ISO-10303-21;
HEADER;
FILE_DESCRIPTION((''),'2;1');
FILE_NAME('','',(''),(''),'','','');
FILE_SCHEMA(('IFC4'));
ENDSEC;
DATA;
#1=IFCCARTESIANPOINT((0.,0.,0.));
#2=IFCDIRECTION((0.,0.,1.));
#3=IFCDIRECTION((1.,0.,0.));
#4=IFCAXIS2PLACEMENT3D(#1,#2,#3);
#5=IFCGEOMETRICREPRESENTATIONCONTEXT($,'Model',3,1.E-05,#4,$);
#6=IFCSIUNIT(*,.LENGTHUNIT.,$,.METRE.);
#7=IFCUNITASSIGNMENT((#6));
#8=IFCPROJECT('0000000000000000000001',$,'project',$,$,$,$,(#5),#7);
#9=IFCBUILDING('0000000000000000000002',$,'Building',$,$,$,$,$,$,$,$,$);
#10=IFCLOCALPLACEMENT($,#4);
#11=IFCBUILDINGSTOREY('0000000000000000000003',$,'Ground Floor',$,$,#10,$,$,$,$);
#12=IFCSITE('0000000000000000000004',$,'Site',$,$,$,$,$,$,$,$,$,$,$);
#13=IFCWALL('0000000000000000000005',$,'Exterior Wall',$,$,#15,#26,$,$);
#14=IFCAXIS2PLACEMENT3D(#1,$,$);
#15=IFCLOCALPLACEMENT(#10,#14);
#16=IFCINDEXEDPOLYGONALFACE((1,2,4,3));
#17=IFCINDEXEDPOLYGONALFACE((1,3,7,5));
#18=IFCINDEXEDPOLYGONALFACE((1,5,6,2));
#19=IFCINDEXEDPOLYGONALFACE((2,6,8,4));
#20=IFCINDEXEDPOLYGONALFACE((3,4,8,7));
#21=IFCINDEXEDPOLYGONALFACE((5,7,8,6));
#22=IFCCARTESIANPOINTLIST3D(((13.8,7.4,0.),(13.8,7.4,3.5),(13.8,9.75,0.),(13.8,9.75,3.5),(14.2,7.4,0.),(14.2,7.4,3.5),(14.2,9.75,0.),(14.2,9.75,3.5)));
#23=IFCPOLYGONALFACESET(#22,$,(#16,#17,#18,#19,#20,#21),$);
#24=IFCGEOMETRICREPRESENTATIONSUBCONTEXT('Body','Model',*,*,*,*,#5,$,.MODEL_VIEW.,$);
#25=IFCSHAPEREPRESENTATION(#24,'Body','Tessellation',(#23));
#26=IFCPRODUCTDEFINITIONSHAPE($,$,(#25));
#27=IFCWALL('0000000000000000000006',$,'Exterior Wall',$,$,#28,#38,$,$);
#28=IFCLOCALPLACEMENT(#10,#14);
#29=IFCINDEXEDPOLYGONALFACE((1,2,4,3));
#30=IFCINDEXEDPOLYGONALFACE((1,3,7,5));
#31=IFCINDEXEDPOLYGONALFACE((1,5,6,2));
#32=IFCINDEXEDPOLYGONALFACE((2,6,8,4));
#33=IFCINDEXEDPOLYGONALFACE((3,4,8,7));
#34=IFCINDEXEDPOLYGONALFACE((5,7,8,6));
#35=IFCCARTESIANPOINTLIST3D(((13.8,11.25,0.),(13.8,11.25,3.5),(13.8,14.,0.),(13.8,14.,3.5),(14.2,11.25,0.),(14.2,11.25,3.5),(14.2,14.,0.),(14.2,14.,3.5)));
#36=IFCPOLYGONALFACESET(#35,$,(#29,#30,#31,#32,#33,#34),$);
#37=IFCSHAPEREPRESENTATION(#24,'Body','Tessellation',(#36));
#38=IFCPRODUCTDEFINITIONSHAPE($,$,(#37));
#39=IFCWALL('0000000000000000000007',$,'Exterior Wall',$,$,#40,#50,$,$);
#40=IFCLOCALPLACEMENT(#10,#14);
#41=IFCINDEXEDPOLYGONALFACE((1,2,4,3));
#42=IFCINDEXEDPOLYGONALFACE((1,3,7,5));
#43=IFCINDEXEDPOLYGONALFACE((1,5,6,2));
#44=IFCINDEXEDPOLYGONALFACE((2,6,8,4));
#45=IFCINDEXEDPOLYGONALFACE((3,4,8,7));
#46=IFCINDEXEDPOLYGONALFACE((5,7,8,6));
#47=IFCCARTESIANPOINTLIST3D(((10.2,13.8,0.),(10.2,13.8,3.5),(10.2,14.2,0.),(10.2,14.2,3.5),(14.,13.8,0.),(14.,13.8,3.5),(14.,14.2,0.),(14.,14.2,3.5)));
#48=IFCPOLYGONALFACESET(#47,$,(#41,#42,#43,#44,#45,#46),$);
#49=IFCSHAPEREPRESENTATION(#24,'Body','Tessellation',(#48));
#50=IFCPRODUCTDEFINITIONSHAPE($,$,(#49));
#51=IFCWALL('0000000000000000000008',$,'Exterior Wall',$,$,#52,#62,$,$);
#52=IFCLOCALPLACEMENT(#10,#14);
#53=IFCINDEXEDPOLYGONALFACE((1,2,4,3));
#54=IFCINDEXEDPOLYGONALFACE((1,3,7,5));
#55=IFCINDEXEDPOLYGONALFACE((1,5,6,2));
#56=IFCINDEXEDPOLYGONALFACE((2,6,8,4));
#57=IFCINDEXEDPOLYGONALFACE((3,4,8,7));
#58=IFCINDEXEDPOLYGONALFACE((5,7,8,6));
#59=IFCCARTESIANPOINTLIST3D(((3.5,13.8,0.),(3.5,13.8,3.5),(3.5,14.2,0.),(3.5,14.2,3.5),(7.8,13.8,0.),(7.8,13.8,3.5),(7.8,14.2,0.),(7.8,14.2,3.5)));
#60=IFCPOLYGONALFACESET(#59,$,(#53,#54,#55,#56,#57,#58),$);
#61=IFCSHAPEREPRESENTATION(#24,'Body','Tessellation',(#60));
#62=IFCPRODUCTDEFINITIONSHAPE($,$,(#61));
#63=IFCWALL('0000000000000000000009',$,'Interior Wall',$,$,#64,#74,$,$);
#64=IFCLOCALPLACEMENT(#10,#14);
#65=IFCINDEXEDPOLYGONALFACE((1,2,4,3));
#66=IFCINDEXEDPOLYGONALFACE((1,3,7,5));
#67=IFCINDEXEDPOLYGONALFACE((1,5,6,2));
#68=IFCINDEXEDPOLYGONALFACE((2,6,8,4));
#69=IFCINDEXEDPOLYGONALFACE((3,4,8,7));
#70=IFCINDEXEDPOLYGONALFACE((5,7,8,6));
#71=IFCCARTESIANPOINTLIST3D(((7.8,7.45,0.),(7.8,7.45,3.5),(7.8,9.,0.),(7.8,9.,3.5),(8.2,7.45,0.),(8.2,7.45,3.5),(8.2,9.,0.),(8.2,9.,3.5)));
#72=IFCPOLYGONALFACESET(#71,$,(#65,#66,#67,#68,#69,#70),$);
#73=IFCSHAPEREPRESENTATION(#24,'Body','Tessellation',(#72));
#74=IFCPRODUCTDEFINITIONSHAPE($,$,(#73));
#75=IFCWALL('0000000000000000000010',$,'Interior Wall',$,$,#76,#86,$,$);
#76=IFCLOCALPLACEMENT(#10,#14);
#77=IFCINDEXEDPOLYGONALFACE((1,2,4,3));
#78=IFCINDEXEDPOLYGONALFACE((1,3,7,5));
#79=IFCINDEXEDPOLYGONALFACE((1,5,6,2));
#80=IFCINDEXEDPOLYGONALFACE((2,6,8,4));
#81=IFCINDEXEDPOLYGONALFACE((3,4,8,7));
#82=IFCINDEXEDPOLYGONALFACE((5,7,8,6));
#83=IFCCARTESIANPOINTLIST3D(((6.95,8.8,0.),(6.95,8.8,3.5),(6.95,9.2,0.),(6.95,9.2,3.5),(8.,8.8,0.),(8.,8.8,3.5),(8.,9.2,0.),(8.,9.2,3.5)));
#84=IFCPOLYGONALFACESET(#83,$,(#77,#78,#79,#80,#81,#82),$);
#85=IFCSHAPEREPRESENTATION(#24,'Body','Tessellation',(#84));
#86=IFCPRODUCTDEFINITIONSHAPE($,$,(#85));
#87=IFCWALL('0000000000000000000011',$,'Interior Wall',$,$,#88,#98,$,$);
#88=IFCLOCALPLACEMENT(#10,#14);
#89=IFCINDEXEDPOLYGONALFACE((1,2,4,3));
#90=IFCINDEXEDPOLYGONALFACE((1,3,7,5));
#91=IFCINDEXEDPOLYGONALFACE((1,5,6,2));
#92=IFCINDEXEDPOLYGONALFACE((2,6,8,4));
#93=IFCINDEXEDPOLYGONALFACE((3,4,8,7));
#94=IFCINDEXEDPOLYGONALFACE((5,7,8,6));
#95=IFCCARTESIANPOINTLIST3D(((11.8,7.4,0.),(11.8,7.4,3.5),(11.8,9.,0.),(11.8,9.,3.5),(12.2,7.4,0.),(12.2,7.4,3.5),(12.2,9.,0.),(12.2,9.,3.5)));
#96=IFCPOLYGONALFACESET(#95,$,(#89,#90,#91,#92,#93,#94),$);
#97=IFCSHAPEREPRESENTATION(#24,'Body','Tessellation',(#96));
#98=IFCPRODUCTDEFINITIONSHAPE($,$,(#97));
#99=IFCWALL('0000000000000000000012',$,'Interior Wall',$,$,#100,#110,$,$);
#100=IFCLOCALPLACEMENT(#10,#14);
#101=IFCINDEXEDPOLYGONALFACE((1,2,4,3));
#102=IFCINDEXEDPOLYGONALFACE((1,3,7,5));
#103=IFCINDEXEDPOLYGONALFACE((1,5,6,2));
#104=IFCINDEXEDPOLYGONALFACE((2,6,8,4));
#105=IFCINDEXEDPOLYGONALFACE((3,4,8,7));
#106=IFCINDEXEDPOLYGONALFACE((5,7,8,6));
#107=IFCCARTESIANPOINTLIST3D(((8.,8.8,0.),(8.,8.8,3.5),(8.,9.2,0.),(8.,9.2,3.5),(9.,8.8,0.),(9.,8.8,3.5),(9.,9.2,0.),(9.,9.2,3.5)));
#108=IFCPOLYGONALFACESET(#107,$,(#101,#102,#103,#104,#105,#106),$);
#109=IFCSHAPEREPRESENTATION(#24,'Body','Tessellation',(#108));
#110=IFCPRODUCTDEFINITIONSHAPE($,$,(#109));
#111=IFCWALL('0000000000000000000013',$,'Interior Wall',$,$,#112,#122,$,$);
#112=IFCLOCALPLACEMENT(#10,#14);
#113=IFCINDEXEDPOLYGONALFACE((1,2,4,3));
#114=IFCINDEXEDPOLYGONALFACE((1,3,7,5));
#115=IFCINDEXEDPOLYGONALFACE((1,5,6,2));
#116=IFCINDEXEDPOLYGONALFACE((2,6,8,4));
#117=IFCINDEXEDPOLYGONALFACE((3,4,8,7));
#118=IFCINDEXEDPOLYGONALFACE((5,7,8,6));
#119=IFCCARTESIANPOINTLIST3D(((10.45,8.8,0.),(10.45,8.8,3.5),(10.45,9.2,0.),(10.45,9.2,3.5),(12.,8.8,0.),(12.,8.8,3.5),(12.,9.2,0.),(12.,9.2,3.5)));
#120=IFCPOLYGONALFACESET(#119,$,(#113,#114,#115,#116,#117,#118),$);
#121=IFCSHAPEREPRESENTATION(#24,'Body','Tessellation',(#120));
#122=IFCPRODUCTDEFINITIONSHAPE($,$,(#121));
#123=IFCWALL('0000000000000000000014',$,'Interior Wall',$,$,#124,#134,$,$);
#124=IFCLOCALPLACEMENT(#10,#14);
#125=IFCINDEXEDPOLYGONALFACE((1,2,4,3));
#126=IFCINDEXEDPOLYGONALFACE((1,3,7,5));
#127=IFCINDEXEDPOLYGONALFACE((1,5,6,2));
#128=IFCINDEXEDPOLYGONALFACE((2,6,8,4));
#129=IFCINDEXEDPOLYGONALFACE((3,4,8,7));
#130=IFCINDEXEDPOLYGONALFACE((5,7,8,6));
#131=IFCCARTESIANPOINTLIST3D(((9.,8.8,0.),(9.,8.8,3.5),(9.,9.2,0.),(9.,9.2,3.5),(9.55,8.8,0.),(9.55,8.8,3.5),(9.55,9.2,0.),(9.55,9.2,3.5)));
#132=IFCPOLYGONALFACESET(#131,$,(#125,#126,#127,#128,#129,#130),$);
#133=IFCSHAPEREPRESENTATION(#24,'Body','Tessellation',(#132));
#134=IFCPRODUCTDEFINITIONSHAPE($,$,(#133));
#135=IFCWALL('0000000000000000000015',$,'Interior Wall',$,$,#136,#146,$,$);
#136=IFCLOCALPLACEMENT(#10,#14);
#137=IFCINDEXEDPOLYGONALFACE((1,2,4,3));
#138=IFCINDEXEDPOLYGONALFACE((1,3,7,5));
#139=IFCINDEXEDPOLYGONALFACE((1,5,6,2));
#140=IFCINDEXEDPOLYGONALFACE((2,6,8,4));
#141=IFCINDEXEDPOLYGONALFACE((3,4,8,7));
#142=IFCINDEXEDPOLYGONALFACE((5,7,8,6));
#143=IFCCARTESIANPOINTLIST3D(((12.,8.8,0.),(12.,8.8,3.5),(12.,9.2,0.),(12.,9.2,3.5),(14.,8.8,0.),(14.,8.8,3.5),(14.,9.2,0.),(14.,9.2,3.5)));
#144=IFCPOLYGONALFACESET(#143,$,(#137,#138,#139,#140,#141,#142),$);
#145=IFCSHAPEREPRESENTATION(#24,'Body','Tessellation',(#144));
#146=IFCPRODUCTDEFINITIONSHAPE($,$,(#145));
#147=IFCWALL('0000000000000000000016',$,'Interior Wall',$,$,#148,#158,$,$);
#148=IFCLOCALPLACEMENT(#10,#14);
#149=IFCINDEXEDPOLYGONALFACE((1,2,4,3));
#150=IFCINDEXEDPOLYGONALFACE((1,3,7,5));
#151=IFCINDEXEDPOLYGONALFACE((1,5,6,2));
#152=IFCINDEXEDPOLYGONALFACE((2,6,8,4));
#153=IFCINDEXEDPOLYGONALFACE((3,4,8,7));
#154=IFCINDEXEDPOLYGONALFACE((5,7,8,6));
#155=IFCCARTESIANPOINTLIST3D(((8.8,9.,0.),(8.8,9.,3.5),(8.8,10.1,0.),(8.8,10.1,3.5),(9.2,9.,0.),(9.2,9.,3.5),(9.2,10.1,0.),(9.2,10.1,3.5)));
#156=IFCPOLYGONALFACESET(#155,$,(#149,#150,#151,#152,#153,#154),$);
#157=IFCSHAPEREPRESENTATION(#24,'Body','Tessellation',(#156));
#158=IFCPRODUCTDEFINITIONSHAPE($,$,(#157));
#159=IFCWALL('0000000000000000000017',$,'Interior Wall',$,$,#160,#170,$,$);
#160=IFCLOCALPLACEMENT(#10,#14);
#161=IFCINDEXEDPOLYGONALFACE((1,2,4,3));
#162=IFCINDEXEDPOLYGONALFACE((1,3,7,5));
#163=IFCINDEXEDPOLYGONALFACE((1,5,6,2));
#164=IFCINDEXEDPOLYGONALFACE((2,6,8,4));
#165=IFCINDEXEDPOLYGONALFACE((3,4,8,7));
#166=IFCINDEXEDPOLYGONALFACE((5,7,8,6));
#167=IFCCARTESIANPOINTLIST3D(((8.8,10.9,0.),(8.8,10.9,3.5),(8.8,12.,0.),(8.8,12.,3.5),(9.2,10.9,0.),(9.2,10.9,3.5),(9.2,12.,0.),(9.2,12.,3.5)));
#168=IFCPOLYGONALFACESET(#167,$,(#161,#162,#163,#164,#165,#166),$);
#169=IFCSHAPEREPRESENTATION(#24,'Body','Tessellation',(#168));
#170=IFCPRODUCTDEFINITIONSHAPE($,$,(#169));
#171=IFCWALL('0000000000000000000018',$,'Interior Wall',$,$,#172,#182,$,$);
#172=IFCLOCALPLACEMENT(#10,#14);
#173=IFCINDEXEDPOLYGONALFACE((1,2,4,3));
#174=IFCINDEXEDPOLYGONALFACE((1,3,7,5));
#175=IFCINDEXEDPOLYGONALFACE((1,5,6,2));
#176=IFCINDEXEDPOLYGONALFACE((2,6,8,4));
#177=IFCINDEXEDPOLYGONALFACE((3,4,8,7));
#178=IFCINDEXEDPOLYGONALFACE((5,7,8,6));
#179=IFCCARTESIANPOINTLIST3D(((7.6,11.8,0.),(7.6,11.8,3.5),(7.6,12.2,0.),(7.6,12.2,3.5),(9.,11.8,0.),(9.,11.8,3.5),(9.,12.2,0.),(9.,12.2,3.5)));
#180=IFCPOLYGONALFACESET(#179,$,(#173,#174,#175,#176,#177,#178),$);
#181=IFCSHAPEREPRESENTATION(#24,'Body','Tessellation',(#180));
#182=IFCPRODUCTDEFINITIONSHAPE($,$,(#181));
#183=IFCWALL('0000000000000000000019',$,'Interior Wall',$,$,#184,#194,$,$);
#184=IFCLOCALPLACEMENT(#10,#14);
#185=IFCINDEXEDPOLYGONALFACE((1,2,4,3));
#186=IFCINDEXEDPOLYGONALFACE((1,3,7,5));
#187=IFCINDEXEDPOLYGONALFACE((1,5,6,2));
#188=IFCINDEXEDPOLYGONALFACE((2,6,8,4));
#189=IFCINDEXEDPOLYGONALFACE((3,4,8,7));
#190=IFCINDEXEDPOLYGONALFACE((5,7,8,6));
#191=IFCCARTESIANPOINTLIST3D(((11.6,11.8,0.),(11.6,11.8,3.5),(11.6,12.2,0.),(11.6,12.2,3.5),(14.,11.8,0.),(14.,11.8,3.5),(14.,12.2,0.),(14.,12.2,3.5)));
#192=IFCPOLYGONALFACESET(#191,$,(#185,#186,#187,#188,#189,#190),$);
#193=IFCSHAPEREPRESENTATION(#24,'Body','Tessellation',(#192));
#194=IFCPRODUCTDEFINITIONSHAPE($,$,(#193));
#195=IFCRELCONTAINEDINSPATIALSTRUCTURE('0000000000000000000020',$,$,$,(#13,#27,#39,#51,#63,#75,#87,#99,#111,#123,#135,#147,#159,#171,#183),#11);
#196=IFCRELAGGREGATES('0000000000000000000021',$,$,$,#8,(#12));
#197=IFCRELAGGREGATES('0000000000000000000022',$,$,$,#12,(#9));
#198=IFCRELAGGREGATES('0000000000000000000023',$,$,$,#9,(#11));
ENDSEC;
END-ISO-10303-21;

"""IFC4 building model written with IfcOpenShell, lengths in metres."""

from ifc_helpers import new_model, si_unit, frame, origin_with_axes, place, context, subcontext, project, spatial, indexed_curve, outline, extrude, element, save


model = new_model("IFC4")

# Units and contexts
model_context = context("Model", 3, precision=1e-05, world=origin_with_axes())
body_context = subcontext(model_context, "Body", "Model", "MODEL_VIEW")
ifc_project = project(units=[si_unit("LENGTHUNIT", "METRE")], contexts=[model_context])

# Site, building, storey
site = spatial("IfcSite", under=ifc_project, Name="Site")
building = spatial("IfcBuilding", under=site, Name="Building")
storey_placement = place(None, origin_with_axes())
storey = spatial("IfcBuildingStorey", under=building, at=storey_placement, Name="Ground Floor")

# Walls
wall_1_placement = place(storey_placement, frame((14.0, 7.4, 0.0), z_axis=(0.0, 0.0, 1.0), x_axis=(0.0, 1.0, 0.0)))
element("IfcWall", 1, at=wall_1_placement, inside=storey, Name="Exterior Wall", context=body_context, shape_type="SweptSolid", body=[
    extrude(outline(indexed_curve([(0.0, 0.0), (0.0, 0.4), (2.35, 0.4), (2.35, 0.0), (0.0, 0.0)], self_intersect=False)), frame((0.0, -0.2, 0.0), z_axis=(0.0, 0.0, 1.0), x_axis=(1.0, 0.0, 0.0)), (0.0, 0.0, 1.0), 3.5),
])
wall_2_placement = place(storey_placement, frame((14.0, 11.25, 0.0), z_axis=(0.0, 0.0, 1.0), x_axis=(0.0, 1.0, 0.0)))
element("IfcWall", 2, at=wall_2_placement, inside=storey, Name="Exterior Wall", context=body_context, shape_type="SweptSolid", body=[
    extrude(outline(indexed_curve([(0.0, 0.0), (0.0, 0.4), (2.75, 0.4), (2.75, 0.0), (0.0, 0.0)], self_intersect=False)), frame((0.0, -0.2, 0.0), z_axis=(0.0, 0.0, 1.0), x_axis=(1.0, 0.0, 0.0)), (0.0, 0.0, 1.0), 3.5),
])
wall_3_placement = place(storey_placement, frame((14.0, 14.0, 0.0), z_axis=(0.0, 0.0, 1.0), x_axis=(-1.0, 0.0, 0.0)))
element("IfcWall", 3, at=wall_3_placement, inside=storey, Name="Exterior Wall", context=body_context, shape_type="SweptSolid", body=[
    extrude(outline(indexed_curve([(0.0, 0.0), (0.0, 0.4), (3.8, 0.4), (3.8, 0.0), (0.0, 0.0)], self_intersect=False)), frame((0.0, -0.2, 0.0), z_axis=(0.0, 0.0, 1.0), x_axis=(1.0, 0.0, 0.0)), (0.0, 0.0, 1.0), 3.5),
])
wall_4_placement = place(storey_placement, frame((7.8, 14.0, 0.0), z_axis=(0.0, 0.0, 1.0), x_axis=(-1.0, 0.0, 0.0)))
element("IfcWall", 4, at=wall_4_placement, inside=storey, Name="Exterior Wall", context=body_context, shape_type="SweptSolid", body=[
    extrude(outline(indexed_curve([(0.0, 0.0), (0.0, 0.4), (4.3, 0.4), (4.3, 0.0), (0.0, 0.0)], self_intersect=False)), frame((0.0, -0.2, 0.0), z_axis=(0.0, 0.0, 1.0), x_axis=(1.0, 0.0, 0.0)), (0.0, 0.0, 1.0), 3.5),
])
wall_5_placement = place(storey_placement, frame((8.0, 7.45, 0.0), z_axis=(0.0, 0.0, 1.0), x_axis=(0.0, 1.0, 0.0)))
element("IfcWall", 5, at=wall_5_placement, inside=storey, Name="Interior Wall", context=body_context, shape_type="SweptSolid", body=[
    extrude(outline(indexed_curve([(0.0, 0.0), (0.0, 0.4), (1.55, 0.4), (1.55, 0.0), (0.0, 0.0)], self_intersect=False)), frame((0.0, -0.2, 0.0), z_axis=(0.0, 0.0, 1.0), x_axis=(1.0, 0.0, 0.0)), (0.0, 0.0, 1.0), 3.5),
])
wall_6_placement = place(storey_placement, frame((8.0, 9.0, 0.0), z_axis=(0.0, 0.0, 1.0), x_axis=(-1.0, 0.0, 0.0)))
element("IfcWall", 6, at=wall_6_placement, inside=storey, Name="Interior Wall", context=body_context, shape_type="SweptSolid", body=[
    extrude(outline(indexed_curve([(0.0, 0.0), (0.0, 0.4), (1.05, 0.4), (1.05, 0.0), (0.0, 0.0)], self_intersect=False)), frame((0.0, -0.2, 0.0), z_axis=(0.0, 0.0, 1.0), x_axis=(1.0, 0.0, 0.0)), (0.0, 0.0, 1.0), 3.5),
])
wall_7_placement = place(storey_placement, frame((12.0, 7.4, 0.0), z_axis=(0.0, 0.0, 1.0), x_axis=(0.0, 1.0, 0.0)))
element("IfcWall", 7, at=wall_7_placement, inside=storey, Name="Interior Wall", context=body_context, shape_type="SweptSolid", body=[
    extrude(outline(indexed_curve([(0.0, 0.0), (0.0, 0.4), (1.6, 0.4), (1.6, 0.0), (0.0, 0.0)], self_intersect=False)), frame((0.0, -0.2, 0.0), z_axis=(0.0, 0.0, 1.0), x_axis=(1.0, 0.0, 0.0)), (0.0, 0.0, 1.0), 3.5),
])
wall_8_placement = place(storey_placement, frame((9.0, 9.0, 0.0), z_axis=(0.0, 0.0, 1.0), x_axis=(-1.0, 0.0, 0.0)))
element("IfcWall", 8, at=wall_8_placement, inside=storey, Name="Interior Wall", context=body_context, shape_type="SweptSolid", body=[
    extrude(outline(indexed_curve([(0.0, 0.0), (0.0, 0.4), (1.0, 0.4), (1.0, 0.0), (0.0, 0.0)], self_intersect=False)), frame((0.0, -0.2, 0.0), z_axis=(0.0, 0.0, 1.0), x_axis=(1.0, 0.0, 0.0)), (0.0, 0.0, 1.0), 3.5),
])
wall_9_placement = place(storey_placement, frame((12.0, 9.0, 0.0), z_axis=(0.0, 0.0, 1.0), x_axis=(-1.0, 0.0, 0.0)))
element("IfcWall", 9, at=wall_9_placement, inside=storey, Name="Interior Wall", context=body_context, shape_type="SweptSolid", body=[
    extrude(outline(indexed_curve([(0.0, 0.0), (0.0, 0.4), (1.55, 0.4), (1.55, 0.0), (0.0, 0.0)], self_intersect=False)), frame((0.0, -0.2, 0.0), z_axis=(0.0, 0.0, 1.0), x_axis=(1.0, 0.0, 0.0)), (0.0, 0.0, 1.0), 3.5),
])
wall_10_placement = place(storey_placement, frame((9.55, 9.0, 0.0), z_axis=(0.0, 0.0, 1.0), x_axis=(-1.0, 0.0, 0.0)))
element("IfcWall", 10, at=wall_10_placement, inside=storey, Name="Interior Wall", context=body_context, shape_type="SweptSolid", body=[
    extrude(outline(indexed_curve([(0.0, 0.0), (0.0, 0.4), (0.55, 0.4), (0.55, 0.0), (0.0, 0.0)], self_intersect=False)), frame((0.0, -0.2, 0.0), z_axis=(0.0, 0.0, 1.0), x_axis=(1.0, 0.0, 0.0)), (0.0, 0.0, 1.0), 3.5),
])
wall_11_placement = place(storey_placement, frame((14.0, 9.0, 0.0), z_axis=(0.0, 0.0, 1.0), x_axis=(-1.0, 0.0, 0.0)))
element("IfcWall", 11, at=wall_11_placement, inside=storey, Name="Interior Wall", context=body_context, shape_type="SweptSolid", body=[
    extrude(outline(indexed_curve([(0.0, 0.0), (0.0, 0.4), (2.0, 0.4), (2.0, 0.0), (0.0, 0.0)], self_intersect=False)), frame((0.0, -0.2, 0.0), z_axis=(0.0, 0.0, 1.0), x_axis=(1.0, 0.0, 0.0)), (0.0, 0.0, 1.0), 3.5),
])
for number, where, z_axis, x_axis, name in (
    (12, (9.0, 9.0, 0.0), (0.0, 0.0, 1.0), (0.0, 1.0, 0.0), "Interior Wall"),
    (13, (9.0, 10.9, 0.0), (0.0, 0.0, 1.0), (0.0, 1.0, 0.0), "Interior Wall"),
):
    element("IfcWall", number, at=place(storey_placement, frame(where, z_axis=z_axis, x_axis=x_axis)), inside=storey, Name=name, context=body_context, shape_type="SweptSolid", body=[
        extrude(outline(indexed_curve([(0.0, 0.0), (0.0, 0.4), (1.1, 0.4), (1.1, 0.0), (0.0, 0.0)], self_intersect=False)), frame((0.0, -0.2, 0.0), z_axis=(0.0, 0.0, 1.0), x_axis=(1.0, 0.0, 0.0)), (0.0, 0.0, 1.0), 3.5),
    ])
wall_12_placement = place(storey_placement, frame((9.0, 12.0, 0.0), z_axis=(0.0, 0.0, 1.0), x_axis=(-1.0, 0.0, 0.0)))
element("IfcWall", 14, at=wall_12_placement, inside=storey, Name="Interior Wall", context=body_context, shape_type="SweptSolid", body=[
    extrude(outline(indexed_curve([(0.0, 0.0), (0.0, 0.4), (1.4, 0.4), (1.4, 0.0), (0.0, 0.0)], self_intersect=False)), frame((0.0, -0.2, 0.0), z_axis=(0.0, 0.0, 1.0), x_axis=(1.0, 0.0, 0.0)), (0.0, 0.0, 1.0), 3.5),
])
wall_13_placement = place(storey_placement, frame((14.0, 12.0, 0.0), z_axis=(0.0, 0.0, 1.0), x_axis=(-1.0, 0.0, 0.0)))
element("IfcWall", 15, at=wall_13_placement, inside=storey, Name="Interior Wall", context=body_context, shape_type="SweptSolid", body=[
    extrude(outline(indexed_curve([(0.0, 0.0), (0.0, 0.4), (2.4, 0.4), (2.4, 0.0), (0.0, 0.0)], self_intersect=False)), frame((0.0, -0.2, 0.0), z_axis=(0.0, 0.0, 1.0), x_axis=(1.0, 0.0, 0.0)), (0.0, 0.0, 1.0), 3.5),
])

save(model, "model.ifc")
